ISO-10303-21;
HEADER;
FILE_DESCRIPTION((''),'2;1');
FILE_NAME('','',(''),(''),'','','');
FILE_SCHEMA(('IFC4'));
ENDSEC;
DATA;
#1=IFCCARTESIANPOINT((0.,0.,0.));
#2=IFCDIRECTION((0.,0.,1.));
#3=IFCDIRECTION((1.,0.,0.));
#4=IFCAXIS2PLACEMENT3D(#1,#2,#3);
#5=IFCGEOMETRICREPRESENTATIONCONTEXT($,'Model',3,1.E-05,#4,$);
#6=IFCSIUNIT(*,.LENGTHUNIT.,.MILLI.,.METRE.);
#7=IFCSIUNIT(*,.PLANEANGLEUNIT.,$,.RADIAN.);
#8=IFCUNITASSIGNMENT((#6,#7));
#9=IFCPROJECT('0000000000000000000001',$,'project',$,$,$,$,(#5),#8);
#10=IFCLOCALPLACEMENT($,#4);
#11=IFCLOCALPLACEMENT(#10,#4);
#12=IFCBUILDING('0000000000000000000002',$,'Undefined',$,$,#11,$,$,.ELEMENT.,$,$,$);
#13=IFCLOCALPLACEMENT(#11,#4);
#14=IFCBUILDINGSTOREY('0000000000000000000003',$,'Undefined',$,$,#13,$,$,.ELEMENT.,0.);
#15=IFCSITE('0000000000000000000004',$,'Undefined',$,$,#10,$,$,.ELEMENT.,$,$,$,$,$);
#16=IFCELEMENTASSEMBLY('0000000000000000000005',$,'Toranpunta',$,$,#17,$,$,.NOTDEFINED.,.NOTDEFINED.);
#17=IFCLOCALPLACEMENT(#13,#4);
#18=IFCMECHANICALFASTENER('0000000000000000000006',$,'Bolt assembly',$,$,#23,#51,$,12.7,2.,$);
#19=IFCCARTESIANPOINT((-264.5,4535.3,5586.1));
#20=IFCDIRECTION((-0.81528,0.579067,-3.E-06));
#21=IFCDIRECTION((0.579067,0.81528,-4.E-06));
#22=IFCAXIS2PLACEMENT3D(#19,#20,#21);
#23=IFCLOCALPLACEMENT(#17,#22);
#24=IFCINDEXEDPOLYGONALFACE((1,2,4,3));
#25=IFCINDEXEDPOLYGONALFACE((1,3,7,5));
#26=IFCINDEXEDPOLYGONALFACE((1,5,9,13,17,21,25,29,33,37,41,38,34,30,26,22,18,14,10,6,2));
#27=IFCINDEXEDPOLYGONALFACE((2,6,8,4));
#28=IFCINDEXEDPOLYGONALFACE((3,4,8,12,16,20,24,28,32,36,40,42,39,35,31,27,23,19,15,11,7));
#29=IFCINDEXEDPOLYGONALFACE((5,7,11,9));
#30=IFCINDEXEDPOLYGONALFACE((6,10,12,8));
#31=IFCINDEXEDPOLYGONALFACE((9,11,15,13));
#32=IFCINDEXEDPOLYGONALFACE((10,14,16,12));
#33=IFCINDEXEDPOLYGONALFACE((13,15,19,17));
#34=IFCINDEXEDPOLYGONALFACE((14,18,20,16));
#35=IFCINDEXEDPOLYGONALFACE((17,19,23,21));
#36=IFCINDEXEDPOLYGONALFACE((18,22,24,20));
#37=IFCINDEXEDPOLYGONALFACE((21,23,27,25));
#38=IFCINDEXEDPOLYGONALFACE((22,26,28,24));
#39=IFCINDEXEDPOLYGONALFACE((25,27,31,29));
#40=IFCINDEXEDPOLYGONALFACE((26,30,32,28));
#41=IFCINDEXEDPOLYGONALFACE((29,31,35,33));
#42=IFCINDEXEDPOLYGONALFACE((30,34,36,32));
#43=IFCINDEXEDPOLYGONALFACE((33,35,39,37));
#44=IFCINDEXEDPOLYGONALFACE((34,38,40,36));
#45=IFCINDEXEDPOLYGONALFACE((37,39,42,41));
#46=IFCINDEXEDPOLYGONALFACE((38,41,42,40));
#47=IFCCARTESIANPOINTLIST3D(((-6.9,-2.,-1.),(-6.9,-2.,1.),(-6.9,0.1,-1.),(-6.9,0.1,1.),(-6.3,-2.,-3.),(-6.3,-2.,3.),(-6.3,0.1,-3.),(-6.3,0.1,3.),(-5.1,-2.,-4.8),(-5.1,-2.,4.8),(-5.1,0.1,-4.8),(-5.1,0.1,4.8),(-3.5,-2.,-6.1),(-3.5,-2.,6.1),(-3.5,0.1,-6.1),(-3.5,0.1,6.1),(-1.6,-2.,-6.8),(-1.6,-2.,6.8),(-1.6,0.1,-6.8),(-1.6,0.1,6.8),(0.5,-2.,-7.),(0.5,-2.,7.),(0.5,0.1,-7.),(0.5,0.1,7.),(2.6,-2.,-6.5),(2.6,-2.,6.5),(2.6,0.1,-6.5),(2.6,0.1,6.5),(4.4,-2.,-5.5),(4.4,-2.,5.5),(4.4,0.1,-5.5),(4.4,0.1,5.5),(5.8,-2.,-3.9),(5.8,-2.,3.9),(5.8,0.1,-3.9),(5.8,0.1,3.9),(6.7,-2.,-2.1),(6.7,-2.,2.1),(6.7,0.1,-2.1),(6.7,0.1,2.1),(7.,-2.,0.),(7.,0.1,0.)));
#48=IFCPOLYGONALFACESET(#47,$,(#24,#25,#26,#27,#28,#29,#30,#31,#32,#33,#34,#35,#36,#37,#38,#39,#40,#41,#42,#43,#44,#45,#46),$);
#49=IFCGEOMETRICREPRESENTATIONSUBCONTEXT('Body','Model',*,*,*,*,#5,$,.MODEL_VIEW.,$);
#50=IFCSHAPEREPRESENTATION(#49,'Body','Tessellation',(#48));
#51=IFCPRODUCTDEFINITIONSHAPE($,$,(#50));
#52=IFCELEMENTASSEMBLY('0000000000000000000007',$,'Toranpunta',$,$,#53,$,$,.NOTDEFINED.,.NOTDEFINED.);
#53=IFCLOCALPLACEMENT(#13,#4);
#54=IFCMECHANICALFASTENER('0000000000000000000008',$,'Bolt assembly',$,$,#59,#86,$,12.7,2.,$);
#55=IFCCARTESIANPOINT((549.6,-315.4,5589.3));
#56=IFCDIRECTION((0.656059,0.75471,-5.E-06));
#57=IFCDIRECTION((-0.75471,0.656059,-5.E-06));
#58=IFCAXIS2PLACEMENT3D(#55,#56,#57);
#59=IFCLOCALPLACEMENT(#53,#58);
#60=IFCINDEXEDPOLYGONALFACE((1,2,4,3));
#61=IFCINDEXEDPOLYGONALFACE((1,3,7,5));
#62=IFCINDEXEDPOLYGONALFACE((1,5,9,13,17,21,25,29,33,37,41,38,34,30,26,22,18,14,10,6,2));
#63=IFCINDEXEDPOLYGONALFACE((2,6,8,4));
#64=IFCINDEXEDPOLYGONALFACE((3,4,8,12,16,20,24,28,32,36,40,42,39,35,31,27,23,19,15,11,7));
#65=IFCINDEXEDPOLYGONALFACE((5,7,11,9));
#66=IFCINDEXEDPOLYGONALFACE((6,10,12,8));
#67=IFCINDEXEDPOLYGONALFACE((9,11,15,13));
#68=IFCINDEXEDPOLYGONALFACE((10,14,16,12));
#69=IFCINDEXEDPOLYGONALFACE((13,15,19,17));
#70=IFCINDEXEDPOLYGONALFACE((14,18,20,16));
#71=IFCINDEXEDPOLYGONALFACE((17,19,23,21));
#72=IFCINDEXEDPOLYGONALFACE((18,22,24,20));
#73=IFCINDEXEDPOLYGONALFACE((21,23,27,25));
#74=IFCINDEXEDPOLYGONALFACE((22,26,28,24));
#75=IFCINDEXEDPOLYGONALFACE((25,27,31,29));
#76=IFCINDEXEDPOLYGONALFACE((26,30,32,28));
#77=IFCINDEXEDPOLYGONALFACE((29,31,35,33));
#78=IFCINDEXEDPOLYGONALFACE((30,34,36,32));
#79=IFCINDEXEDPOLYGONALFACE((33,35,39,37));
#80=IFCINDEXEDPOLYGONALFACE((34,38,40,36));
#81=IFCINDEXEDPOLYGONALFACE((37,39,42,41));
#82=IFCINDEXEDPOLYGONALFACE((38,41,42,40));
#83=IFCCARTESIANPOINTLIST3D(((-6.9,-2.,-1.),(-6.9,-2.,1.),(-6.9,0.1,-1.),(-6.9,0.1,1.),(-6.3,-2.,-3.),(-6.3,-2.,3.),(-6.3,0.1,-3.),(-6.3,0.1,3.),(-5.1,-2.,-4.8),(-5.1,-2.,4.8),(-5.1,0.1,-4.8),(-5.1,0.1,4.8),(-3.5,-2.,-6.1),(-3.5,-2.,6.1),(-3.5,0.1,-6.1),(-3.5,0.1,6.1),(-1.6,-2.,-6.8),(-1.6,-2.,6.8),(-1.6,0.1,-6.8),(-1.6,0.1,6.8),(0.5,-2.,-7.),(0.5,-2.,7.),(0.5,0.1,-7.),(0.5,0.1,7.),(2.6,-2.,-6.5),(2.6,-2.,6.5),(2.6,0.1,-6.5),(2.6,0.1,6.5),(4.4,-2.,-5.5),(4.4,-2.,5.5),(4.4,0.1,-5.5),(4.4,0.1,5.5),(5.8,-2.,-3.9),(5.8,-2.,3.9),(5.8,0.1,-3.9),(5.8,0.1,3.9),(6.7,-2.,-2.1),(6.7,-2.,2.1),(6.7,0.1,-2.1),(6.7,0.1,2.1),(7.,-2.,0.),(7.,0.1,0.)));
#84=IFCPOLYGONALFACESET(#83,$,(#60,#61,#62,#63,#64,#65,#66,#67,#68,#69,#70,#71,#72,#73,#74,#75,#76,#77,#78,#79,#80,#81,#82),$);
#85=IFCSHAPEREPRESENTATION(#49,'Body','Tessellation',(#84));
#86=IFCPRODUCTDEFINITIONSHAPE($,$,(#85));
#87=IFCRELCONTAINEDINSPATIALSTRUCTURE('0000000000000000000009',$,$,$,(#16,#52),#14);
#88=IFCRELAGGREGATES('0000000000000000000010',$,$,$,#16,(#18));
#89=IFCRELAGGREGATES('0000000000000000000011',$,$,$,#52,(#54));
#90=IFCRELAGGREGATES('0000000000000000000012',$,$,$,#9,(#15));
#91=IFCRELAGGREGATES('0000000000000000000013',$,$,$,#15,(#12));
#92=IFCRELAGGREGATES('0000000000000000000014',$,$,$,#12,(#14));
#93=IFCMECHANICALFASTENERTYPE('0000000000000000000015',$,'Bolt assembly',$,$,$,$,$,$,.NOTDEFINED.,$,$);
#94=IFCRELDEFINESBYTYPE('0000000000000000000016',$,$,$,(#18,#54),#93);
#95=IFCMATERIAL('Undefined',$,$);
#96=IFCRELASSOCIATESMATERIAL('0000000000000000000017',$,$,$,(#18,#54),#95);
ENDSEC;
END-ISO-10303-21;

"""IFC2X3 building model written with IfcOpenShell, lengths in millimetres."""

from ifc_helpers import new_model, si_unit, frame, origin_with_axes, origin_2d_with_axis, place, context, subcontext, project, spatial, circle, extrude, source, transform, mapped, material, type_object, element, aggregate, save


model = new_model("IFC2X3")

# Units and contexts
model_context = context("Model", 3, precision=1e-05, world=origin_with_axes())
body_context = subcontext(model_context, "Body", "Model", "MODEL_VIEW")
ifc_project = project(units=[si_unit("LENGTHUNIT", "METRE", prefix="MILLI"), si_unit("PLANEANGLEUNIT", "RADIAN")], contexts=[model_context])

# Site, building, storey
site_placement = place(None, origin_with_axes())
site = spatial("IfcSite", under=ifc_project, at=site_placement, Name="Undefined", CompositionType="ELEMENT")
building_placement = place(site_placement, origin_with_axes())
building = spatial("IfcBuilding", under=site, at=building_placement, Name="Undefined", CompositionType="ELEMENT")
storey_placement = place(building_placement, origin_with_axes())
storey = spatial("IfcBuildingStorey", under=building, at=storey_placement, Name="Undefined", CompositionType="ELEMENT", Elevation=0.0)

# Element assembly, mechanical fastener
assembly_1_placement = place(storey_placement, origin_with_axes())
assembly_1 = element("IfcElementAssembly", 1, at=assembly_1_placement, inside=storey, Name="Toranpunta", AssemblyPlace="NOTDEFINED", PredefinedType="NOTDEFINED")
ifc_material_1 = material(Name="Undefined")
mechanical_fastener_type = type_object("IfcMechanicalFastenerType", Name="Bolt assembly")
shared_shape_1 = source(origin_with_axes(), body_context, "Body", "SweptSolid", [
    extrude(circle(Radius=7.0, at=origin_2d_with_axis()), frame((0.0, -2.0, 0.0), z_axis=(0.0, 1.0, 0.0), x_axis=(1.0, 0.0, 0.0)), (0.0, 0.0, 1.0), 2.1),
])
mechanical_fastener_1_placement = place(assembly_1_placement, frame((-264.5, 4535.3, 5586.1), z_axis=(-0.81528, 0.579067, -0.000003), x_axis=(0.579067, 0.81528, -0.000004)))
mechanical_fastener_1 = element("IfcMechanicalFastener", 2, at=mechanical_fastener_1_placement, type_object=mechanical_fastener_type, material=ifc_material_1, Name="Bolt assembly", NominalDiameter=12.7, NominalLength=2.0, context=body_context, shape_type="MappedRepresentation", body=[
    mapped(shared_shape_1, transform((0.0, 0.0, 0.0))),
])
aggregate(assembly_1, [mechanical_fastener_1])

# Element assembly, mechanical fastener
assembly_2_placement = place(storey_placement, origin_with_axes())
assembly_2 = element("IfcElementAssembly", 3, at=assembly_2_placement, inside=storey, Name="Toranpunta", AssemblyPlace="NOTDEFINED", PredefinedType="NOTDEFINED")
mechanical_fastener_2_placement = place(assembly_2_placement, frame((549.6, -315.4, 5589.3), z_axis=(0.656059, 0.75471, -0.000005), x_axis=(-0.75471, 0.656059, -0.000005)))
mechanical_fastener_2 = element("IfcMechanicalFastener", 4, at=mechanical_fastener_2_placement, type_object=mechanical_fastener_type, material=ifc_material_1, Name="Bolt assembly", NominalDiameter=12.7, NominalLength=2.0, context=body_context, shape_type="MappedRepresentation", body=[
    mapped(shared_shape_1, transform((0.0, 0.0, 0.0))),
])
aggregate(assembly_2, [mechanical_fastener_2])

save(model, "model.ifc")
